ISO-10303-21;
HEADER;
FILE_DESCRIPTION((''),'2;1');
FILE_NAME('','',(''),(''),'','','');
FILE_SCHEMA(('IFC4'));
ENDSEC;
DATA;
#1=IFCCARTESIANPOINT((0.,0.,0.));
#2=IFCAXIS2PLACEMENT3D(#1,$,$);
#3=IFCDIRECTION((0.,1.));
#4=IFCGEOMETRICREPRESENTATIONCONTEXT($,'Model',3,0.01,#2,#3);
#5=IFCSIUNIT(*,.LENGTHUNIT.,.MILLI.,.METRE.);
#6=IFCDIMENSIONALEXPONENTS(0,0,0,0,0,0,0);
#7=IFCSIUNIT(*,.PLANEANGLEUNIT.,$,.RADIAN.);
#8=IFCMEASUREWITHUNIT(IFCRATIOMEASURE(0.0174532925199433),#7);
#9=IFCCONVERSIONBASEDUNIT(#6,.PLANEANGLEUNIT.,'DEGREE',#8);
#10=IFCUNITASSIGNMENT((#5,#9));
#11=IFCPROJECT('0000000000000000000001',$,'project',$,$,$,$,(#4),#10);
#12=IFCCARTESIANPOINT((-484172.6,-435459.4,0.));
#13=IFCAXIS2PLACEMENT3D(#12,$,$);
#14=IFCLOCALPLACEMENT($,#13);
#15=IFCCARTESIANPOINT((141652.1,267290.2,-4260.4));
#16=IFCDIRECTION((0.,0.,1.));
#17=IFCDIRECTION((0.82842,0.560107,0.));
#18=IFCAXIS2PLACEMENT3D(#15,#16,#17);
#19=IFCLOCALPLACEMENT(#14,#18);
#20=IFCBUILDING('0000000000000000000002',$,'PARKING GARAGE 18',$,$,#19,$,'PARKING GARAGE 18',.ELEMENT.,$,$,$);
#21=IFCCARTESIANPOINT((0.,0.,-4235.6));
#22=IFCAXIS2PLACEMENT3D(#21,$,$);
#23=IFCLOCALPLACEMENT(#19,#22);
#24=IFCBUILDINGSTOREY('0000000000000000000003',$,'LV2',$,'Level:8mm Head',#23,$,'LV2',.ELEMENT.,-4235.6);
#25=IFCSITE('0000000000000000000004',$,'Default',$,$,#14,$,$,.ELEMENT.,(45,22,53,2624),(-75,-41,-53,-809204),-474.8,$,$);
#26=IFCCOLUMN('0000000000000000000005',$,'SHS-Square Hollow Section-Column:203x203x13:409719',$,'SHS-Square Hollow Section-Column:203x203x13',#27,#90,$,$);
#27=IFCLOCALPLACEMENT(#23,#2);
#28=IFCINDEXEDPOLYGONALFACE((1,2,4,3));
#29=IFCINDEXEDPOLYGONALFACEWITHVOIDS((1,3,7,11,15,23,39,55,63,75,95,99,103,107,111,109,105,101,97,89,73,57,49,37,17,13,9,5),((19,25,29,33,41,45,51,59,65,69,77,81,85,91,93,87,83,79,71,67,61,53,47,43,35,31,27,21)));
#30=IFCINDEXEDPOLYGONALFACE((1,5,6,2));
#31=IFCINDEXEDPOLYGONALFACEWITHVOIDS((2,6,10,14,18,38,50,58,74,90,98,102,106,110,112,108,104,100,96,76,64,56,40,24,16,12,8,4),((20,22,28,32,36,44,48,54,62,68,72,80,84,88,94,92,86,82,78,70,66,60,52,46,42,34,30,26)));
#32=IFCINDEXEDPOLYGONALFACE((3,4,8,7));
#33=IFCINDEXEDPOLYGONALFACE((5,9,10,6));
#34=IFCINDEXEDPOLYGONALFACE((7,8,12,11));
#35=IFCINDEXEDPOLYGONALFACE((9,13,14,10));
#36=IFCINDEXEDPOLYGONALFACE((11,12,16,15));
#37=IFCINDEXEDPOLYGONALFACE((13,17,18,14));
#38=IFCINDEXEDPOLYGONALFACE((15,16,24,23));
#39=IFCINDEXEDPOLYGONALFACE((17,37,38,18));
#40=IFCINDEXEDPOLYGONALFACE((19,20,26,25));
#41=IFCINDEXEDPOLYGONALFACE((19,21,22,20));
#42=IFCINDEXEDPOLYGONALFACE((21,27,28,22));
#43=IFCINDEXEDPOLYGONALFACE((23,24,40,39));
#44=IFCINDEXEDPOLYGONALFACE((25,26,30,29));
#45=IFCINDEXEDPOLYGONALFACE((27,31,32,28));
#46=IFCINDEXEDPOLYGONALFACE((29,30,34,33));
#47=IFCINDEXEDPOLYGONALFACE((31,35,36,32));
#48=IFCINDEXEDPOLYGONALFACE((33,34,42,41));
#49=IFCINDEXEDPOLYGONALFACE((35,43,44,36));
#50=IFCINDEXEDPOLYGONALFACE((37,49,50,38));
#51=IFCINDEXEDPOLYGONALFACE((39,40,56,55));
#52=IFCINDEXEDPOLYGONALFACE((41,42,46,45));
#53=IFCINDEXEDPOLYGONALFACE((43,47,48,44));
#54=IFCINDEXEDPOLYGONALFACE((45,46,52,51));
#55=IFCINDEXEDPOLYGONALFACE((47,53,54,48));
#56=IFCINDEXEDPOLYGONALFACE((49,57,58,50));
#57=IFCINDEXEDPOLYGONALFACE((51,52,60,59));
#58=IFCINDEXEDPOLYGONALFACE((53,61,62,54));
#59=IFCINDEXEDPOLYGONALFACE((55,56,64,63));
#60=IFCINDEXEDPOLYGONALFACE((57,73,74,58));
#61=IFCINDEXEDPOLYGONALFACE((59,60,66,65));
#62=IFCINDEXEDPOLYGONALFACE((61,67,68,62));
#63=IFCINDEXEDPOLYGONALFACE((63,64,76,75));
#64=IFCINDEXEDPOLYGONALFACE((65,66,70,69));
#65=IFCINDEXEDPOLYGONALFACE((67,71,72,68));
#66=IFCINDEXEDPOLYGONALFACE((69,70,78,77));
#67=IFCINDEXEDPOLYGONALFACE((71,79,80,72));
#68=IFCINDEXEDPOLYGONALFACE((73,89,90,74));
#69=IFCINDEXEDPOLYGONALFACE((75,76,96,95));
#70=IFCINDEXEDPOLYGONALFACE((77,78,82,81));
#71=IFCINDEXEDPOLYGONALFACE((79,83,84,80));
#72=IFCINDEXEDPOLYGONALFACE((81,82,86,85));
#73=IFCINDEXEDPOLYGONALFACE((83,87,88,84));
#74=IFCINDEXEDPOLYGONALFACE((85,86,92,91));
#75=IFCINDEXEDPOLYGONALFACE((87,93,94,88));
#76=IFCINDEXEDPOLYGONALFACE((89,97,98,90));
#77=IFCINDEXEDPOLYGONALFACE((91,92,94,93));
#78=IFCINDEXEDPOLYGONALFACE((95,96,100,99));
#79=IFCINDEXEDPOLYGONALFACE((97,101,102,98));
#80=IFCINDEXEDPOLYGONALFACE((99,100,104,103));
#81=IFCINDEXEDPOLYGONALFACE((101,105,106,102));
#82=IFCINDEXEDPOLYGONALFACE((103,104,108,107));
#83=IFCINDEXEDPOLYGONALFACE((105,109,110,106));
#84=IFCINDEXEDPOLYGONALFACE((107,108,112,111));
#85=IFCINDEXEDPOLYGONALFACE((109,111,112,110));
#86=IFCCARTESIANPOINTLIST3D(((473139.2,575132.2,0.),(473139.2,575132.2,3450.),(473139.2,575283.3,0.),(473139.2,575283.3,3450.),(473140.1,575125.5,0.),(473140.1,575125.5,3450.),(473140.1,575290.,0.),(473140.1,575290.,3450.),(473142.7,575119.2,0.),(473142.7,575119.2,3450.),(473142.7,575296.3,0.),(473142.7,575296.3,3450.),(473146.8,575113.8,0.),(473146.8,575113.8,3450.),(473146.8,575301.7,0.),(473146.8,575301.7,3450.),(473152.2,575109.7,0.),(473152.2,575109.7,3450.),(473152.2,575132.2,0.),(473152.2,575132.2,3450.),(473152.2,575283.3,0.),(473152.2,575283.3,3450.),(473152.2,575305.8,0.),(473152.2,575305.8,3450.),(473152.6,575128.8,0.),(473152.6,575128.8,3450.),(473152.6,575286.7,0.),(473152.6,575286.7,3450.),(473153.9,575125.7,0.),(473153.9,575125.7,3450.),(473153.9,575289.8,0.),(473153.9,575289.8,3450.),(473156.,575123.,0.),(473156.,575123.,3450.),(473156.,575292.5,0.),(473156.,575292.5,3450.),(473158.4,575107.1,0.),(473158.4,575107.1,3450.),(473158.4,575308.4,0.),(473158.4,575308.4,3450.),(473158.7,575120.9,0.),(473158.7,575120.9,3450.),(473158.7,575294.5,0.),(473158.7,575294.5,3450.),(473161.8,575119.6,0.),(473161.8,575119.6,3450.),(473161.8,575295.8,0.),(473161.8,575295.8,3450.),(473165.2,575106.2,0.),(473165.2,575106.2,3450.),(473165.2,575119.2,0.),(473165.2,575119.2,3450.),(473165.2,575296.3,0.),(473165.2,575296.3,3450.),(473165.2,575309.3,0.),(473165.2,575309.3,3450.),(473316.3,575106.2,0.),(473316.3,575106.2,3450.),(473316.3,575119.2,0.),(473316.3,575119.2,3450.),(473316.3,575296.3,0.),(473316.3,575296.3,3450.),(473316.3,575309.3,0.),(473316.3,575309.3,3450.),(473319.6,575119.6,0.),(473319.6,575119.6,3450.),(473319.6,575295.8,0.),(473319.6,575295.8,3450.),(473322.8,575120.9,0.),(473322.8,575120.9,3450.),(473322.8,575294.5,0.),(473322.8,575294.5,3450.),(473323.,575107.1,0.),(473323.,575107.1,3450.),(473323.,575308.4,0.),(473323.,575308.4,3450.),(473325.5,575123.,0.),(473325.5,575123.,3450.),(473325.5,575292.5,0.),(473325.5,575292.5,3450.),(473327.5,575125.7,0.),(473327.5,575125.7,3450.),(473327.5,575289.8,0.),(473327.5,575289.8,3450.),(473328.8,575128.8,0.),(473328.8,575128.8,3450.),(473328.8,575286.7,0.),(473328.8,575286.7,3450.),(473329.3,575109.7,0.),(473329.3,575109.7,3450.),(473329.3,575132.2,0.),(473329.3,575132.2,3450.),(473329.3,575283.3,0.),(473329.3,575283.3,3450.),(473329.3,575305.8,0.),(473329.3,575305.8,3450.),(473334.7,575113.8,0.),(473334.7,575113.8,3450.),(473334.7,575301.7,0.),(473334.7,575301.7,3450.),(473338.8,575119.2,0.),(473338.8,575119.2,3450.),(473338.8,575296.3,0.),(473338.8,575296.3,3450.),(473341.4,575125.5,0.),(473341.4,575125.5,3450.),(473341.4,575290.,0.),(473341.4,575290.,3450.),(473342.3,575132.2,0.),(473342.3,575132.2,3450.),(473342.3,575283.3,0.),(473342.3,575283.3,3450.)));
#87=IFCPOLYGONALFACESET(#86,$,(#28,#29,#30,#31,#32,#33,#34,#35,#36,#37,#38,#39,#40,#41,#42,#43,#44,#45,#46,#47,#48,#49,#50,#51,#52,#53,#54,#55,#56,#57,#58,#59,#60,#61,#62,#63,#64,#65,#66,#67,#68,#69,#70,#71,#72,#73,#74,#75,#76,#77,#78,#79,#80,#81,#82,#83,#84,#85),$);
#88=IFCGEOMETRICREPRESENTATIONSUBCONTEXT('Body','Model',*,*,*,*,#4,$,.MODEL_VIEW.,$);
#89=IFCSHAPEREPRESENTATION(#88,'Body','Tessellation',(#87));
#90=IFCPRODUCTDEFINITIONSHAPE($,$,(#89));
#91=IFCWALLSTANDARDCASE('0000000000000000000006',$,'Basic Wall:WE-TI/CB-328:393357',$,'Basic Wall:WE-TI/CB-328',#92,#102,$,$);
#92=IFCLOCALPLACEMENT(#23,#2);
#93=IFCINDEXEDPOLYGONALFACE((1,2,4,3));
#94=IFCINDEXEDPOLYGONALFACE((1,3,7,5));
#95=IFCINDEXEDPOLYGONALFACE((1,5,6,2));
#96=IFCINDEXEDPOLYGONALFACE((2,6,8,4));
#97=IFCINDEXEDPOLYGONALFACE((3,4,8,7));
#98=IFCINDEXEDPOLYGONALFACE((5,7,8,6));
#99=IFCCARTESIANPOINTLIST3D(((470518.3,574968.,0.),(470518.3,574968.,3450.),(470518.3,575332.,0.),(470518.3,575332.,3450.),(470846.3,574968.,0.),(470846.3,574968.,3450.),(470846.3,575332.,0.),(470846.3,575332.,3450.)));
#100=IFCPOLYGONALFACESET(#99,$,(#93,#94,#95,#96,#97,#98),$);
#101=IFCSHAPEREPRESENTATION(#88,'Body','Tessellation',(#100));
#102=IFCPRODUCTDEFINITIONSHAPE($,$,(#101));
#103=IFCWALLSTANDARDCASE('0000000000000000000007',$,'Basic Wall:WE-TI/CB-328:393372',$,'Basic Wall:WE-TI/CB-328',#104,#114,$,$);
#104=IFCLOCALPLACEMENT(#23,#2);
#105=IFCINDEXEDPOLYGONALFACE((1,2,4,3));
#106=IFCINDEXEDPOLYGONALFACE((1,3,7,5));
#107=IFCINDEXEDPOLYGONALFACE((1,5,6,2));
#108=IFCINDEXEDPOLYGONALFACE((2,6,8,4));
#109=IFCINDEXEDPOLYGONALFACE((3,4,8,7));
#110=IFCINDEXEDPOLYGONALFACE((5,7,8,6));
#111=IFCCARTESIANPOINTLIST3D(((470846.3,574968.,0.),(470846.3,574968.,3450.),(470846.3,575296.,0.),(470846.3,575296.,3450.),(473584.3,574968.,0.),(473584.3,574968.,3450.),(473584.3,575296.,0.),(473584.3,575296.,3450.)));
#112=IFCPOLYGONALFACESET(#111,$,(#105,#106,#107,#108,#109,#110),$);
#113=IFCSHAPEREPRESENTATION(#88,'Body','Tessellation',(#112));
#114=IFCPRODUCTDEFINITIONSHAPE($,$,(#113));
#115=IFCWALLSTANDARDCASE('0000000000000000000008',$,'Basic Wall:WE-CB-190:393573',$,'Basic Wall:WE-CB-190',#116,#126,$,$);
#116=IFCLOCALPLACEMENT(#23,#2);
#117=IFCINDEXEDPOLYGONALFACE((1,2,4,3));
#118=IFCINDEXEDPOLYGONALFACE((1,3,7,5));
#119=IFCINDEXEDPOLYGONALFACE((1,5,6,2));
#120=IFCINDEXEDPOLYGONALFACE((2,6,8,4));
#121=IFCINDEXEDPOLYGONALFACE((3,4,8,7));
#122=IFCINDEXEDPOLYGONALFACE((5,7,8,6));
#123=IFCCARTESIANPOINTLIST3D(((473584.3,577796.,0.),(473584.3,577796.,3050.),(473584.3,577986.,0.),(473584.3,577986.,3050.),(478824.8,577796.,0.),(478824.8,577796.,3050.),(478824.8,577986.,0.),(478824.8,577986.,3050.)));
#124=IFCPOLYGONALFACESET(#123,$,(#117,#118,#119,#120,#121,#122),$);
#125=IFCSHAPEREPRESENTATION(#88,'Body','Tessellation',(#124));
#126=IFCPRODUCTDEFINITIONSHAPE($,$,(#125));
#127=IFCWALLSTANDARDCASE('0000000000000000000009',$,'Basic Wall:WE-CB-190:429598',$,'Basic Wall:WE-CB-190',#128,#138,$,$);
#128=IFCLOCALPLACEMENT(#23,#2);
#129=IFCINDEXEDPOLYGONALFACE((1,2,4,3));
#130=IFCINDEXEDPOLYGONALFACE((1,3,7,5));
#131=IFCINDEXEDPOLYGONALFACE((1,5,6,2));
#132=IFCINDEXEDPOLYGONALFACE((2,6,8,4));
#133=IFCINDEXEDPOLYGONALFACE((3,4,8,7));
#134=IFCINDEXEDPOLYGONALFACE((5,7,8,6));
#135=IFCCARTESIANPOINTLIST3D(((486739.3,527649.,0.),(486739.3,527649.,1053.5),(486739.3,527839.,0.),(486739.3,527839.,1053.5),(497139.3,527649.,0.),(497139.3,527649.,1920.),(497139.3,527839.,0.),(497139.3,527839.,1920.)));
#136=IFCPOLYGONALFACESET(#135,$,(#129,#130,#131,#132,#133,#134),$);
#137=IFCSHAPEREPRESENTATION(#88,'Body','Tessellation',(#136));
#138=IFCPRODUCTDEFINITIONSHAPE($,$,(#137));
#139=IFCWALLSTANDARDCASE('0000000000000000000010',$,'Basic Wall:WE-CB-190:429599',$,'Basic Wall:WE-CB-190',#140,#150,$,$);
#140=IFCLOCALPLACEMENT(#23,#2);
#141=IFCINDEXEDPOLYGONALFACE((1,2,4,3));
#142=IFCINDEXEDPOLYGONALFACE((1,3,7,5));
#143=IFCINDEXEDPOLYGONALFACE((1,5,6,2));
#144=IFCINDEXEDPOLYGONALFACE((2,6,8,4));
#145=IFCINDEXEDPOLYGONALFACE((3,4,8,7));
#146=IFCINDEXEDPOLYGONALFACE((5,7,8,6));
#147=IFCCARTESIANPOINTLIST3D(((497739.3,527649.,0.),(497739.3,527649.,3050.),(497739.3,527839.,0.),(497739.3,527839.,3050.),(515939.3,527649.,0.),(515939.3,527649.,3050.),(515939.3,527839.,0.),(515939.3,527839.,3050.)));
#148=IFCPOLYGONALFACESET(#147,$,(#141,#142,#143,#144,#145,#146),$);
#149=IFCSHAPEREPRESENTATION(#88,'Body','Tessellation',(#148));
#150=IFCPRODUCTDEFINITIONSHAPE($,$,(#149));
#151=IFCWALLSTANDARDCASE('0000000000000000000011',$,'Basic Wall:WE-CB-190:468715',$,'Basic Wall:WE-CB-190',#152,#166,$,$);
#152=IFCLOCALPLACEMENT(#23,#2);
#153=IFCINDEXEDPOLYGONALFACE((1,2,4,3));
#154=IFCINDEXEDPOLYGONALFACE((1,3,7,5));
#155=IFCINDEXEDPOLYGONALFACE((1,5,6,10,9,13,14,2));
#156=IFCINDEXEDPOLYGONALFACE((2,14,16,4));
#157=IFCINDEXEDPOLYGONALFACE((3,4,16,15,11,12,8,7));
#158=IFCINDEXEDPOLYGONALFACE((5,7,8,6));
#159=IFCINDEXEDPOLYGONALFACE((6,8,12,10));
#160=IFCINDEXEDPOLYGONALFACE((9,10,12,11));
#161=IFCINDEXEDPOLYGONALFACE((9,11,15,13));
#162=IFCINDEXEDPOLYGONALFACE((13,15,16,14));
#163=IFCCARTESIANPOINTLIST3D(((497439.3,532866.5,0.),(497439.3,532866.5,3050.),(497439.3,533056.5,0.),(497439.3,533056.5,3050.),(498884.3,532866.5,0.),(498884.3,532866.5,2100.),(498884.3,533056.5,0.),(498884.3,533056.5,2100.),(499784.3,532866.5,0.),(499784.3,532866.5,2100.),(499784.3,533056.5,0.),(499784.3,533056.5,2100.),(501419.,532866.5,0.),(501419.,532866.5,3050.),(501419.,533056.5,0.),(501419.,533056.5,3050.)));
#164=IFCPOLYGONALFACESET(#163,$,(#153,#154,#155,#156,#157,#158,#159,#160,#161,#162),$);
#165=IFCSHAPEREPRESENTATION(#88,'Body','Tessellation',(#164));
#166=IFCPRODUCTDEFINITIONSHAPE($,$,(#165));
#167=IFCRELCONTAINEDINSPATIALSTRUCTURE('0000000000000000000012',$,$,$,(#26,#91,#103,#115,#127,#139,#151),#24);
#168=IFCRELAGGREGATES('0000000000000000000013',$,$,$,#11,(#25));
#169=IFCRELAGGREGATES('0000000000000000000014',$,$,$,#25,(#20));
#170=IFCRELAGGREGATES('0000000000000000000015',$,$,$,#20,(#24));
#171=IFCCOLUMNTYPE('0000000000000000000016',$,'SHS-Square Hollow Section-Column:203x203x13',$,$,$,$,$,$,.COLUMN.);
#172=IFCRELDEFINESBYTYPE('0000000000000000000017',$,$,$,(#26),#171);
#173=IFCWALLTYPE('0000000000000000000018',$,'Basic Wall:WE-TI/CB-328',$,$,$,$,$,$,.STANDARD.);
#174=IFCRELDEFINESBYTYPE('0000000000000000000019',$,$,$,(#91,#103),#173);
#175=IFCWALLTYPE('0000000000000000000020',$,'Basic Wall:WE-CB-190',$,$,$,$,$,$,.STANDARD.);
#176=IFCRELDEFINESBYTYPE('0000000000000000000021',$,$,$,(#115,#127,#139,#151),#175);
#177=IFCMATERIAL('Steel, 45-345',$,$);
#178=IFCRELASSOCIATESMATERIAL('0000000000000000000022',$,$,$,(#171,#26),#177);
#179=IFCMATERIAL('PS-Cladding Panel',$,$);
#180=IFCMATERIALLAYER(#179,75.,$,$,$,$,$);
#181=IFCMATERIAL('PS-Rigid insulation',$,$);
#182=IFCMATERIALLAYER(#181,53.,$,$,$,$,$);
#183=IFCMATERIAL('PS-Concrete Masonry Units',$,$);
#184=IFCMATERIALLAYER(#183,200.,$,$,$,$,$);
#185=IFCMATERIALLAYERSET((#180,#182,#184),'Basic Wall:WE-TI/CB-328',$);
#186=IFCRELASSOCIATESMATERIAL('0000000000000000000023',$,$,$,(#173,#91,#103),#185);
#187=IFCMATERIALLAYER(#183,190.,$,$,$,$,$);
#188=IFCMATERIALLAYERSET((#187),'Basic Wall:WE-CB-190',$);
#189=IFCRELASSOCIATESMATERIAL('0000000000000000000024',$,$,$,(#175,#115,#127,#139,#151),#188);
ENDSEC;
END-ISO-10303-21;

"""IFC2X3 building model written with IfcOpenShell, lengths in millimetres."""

from ifc_helpers import new_model, entity, si_unit, converted_unit, direction, frame, frame_2d, origin, place, context, subcontext, project, spatial, polyline, circle_curve, parameter, trimmed, segment, composite_curve, rectangle, outline, extrude, clip, halfspace, source, transform, mapped, material, layer, layer_set, layer_usage, type_object, type_shapes, element, save


model = new_model("IFC2X3")

# Units and contexts
model_context = context("Model", 3, precision=0.01, world=origin(), true_north=direction((0.0, 1.0)))
body_context = subcontext(model_context, "Body", "Model", "MODEL_VIEW")
ifc_project = project(units=[si_unit("LENGTHUNIT", "METRE", prefix="MILLI"), converted_unit("PLANEANGLEUNIT", "DEGREE", entity("IfcRatioMeasure", 0.0174532925199433), si_unit("PLANEANGLEUNIT", "RADIAN"), dimensions=[0, 0, 0, 0, 0, 0, 0])], contexts=[model_context])

# Site, building, storey
site_placement = place(None, frame((-484172.6, -435459.4, 0.0)))
site = spatial("IfcSite", under=ifc_project, at=site_placement, Name="Default", CompositionType="ELEMENT", RefLatitude=(45, 22, 53, 2624), RefLongitude=(-75, -41, -53, -809204), RefElevation=-474.8)
building_placement = place(site_placement, frame((141652.1, 267290.2, -4260.4), z_axis=(0.0, 0.0, 1.0), x_axis=(0.82842, 0.560107, 0.0)))
building = spatial("IfcBuilding", under=site, at=building_placement, Name="PARKING GARAGE 18", LongName="PARKING GARAGE 18", CompositionType="ELEMENT")
storey_placement = place(building_placement, frame((0.0, 0.0, -4235.6)))
storey = spatial("IfcBuildingStorey", under=building, at=storey_placement, Name="LV2", ObjectType="Level:8mm Head", LongName="LV2", CompositionType="ELEMENT", Elevation=-4235.6)

# Column
ifc_material_1 = material(Name="Steel, 45-345")
column_type = type_object("IfcColumnType", Name="SHS-Square Hollow Section-Column:203x203x13", PredefinedType="COLUMN", material=ifc_material_1)
shared_shape_1 = source(origin(), body_context, "Body", "SweptSolid", [
    extrude(outline(composite_curve([segment(polyline([(-75.6, -101.5), (75.6, -101.5)]), True, "CONTINUOUS"), segment(trimmed(circle_curve(frame_2d((75.6, -75.6), x_axis=(-1.0, 0.0)), 26.0), [parameter(90.0)], [parameter(180.0)], True, "PARAMETER"), True, "CONTINUOUS"), segment(polyline([(101.5, -75.6), (101.5, 75.6)]), True, "CONTINUOUS"), segment(trimmed(circle_curve(frame_2d((75.5, 75.6), x_axis=(-1.0, 0.0)), 26.0), [parameter(180.0)], [parameter(270.0)], True, "PARAMETER"), True, "CONTINUOUS"), segment(polyline([(75.5, 101.6), (-75.5, 101.6)]), True, "CONTINUOUS"), segment(trimmed(circle_curve(frame_2d((-75.5, 75.5), x_axis=(-1.0, 0.0)), 26.0), [parameter(270.0)], [parameter(360.0)], True, "PARAMETER"), True, "CONTINUOUS"), segment(polyline([(-101.5, 75.5), (-101.5, -75.6)]), True, "CONTINUOUS"), segment(trimmed(circle_curve(frame_2d((-75.6, -75.6), x_axis=(-1.0, 0.0)), 26.0), [parameter(360.0)], [parameter(90.0)], True, "PARAMETER"), True, "CONTINUOUS")], self_intersect=False), holes=[composite_curve([segment(trimmed(circle_curve(frame_2d((-75.6, -75.6), x_axis=(-1.0, 0.0)), 13.0), [parameter(0.0)], [parameter(90.0)], True, "PARAMETER"), False, "CONTINUOUS"), segment(polyline([(-88.5, -75.6), (-88.5, 75.6)]), True, "CONTINUOUS"), segment(trimmed(circle_curve(frame_2d((-75.6, 75.6), x_axis=(-1.0, 0.0)), 13.0), [parameter(270.0)], [parameter(0.0)], True, "PARAMETER"), False, "CONTINUOUS"), segment(polyline([(-75.6, 88.6), (75.5, 88.6)]), True, "CONTINUOUS"), segment(trimmed(circle_curve(frame_2d((75.5, 75.5), x_axis=(-1.0, 0.0)), 13.0), [parameter(180.0)], [parameter(270.0)], True, "PARAMETER"), False, "CONTINUOUS"), segment(polyline([(88.6, 75.5), (88.6, -75.5)]), True, "CONTINUOUS"), segment(trimmed(circle_curve(frame_2d((75.6, -75.5), x_axis=(-1.0, 0.0)), 13.0), [parameter(90.0)], [parameter(180.0)], True, "PARAMETER"), False, "CONTINUOUS"), segment(polyline([(75.6, -88.5), (-75.6, -88.5)]), True, "CONTINUOUS")], self_intersect=False)]), frame((0.0, 0.0, -4235.6), z_axis=(0.0, 0.0, 1.0), x_axis=(-1.0, 0.0, 0.0)), (0.0, 0.0, 1.0), 3450.0),
])
type_shapes(column_type, [shared_shape_1])
for number, where, name in (
    (1, (473240.7, 575207.7, 4235.6), "SHS-Square Hollow Section-Column:203x203x13:409719"),
):
    element("IfcColumn", number, at=place(storey_placement, frame(where)), inside=storey, type_object=column_type, material=ifc_material_1, Name=name, ObjectType="SHS-Square Hollow Section-Column:203x203x13", context=body_context, shape_type="MappedRepresentation", body=[
        mapped(shared_shape_1, transform((0.0, 0.0, 0.0), scale=1.0)),
    ])

# Walls
ifc_material_2 = material(Name="PS-Cladding Panel")
ifc_layer_1 = layer(ifc_material_2, 75.0)
ifc_material_3 = material(Name="PS-Rigid insulation")
ifc_layer_2 = layer(ifc_material_3, 53.0)
ifc_material_4 = material(Name="PS-Concrete Masonry Units")
ifc_layer_3 = layer(ifc_material_4, 200.0)
ifc_layer_set_1 = layer_set([ifc_layer_1, ifc_layer_2, ifc_layer_3], Name="Basic Wall:WE-TI/CB-328")
ifc_layer_usage_1 = layer_usage(ifc_layer_set_1, "AXIS2", "POSITIVE", -164.0)
wall_type_1 = type_object("IfcWallType", Name="Basic Wall:WE-TI/CB-328", PredefinedType="STANDARD", material=ifc_layer_set_1)
wall_1_placement = place(storey_placement, frame((470682.3, 575332.0, 0.0), z_axis=(0.0, 0.0, 1.0), x_axis=(0.0, -1.0, 0.0)))
element("IfcWallStandardCase", 2, at=wall_1_placement, inside=storey, type_object=wall_type_1, material=ifc_layer_usage_1, Name="Basic Wall:WE-TI/CB-328:393357", ObjectType="Basic Wall:WE-TI/CB-328", context=body_context, shape_type="SweptSolid", body=[
    extrude(rectangle(XDim=364.0, YDim=328.0, at=frame_2d((182.0, 0.0), x_axis=(-1.0, 0.0))), origin(), (0.0, 0.0, 1.0), 3450.0),
])
ifc_layer_usage_2 = layer_usage(ifc_layer_set_1, "AXIS2", "POSITIVE", -164.0)
wall_2_placement = place(storey_placement, frame((470846.3, 575132.0, 0.0)))
element("IfcWallStandardCase", 3, at=wall_2_placement, inside=storey, type_object=wall_type_1, material=ifc_layer_usage_2, Name="Basic Wall:WE-TI/CB-328:393372", ObjectType="Basic Wall:WE-TI/CB-328", context=body_context, shape_type="SweptSolid", body=[
    extrude(rectangle(XDim=2738.0, YDim=328.0, at=frame_2d((1369.0, 0.0), x_axis=(-1.0, 0.0))), origin(), (0.0, 0.0, 1.0), 3450.0),
])
ifc_layer_4 = layer(ifc_material_4, 190.0)
ifc_layer_set_2 = layer_set([ifc_layer_4], Name="Basic Wall:WE-CB-190")
ifc_layer_usage_3 = layer_usage(ifc_layer_set_2, "AXIS2", "NEGATIVE", 95.0)
wall_type_2 = type_object("IfcWallType", Name="Basic Wall:WE-CB-190", PredefinedType="STANDARD", material=ifc_layer_set_2)
wall_3_placement = place(storey_placement, frame((473584.3, 577891.0, 0.0)))
element("IfcWallStandardCase", 4, at=wall_3_placement, inside=storey, type_object=wall_type_2, material=ifc_layer_usage_3, Name="Basic Wall:WE-CB-190:393573", ObjectType="Basic Wall:WE-CB-190", context=body_context, shape_type="SweptSolid", body=[
    extrude(rectangle(XDim=5240.5, YDim=190.0, at=frame_2d((2620.2, 0.0), x_axis=(-1.0, 0.0))), origin(), (0.0, 0.0, 1.0), 3050.0),
])
ifc_layer_usage_4 = layer_usage(ifc_layer_set_2, "AXIS2", "NEGATIVE", 95.0)
wall_4_placement = place(storey_placement, frame((486739.3, 527744.0, 0.0)))
element("IfcWallStandardCase", 5, at=wall_4_placement, inside=storey, type_object=wall_type_2, material=ifc_layer_usage_4, Name="Basic Wall:WE-CB-190:429598", ObjectType="Basic Wall:WE-CB-190", context=body_context, shape_type="Clipping", body=[
    clip(extrude(rectangle(XDim=10400.0, YDim=190.0, at=frame_2d((5200.0, 0.0), x_axis=(-1.0, 0.0))), origin(), (0.0, 0.0, 1.0), 1920.0), halfspace(frame((0.0, -95.0, 1053.5), z_axis=(-0.083029, 0.0, 0.996547), x_axis=(0.0, 1.0, 0.0)), False)),
])
ifc_layer_usage_5 = layer_usage(ifc_layer_set_2, "AXIS2", "NEGATIVE", 95.0)
wall_5_placement = place(storey_placement, frame((497739.3, 527744.0, 0.0)))
element("IfcWallStandardCase", 6, at=wall_5_placement, inside=storey, type_object=wall_type_2, material=ifc_layer_usage_5, Name="Basic Wall:WE-CB-190:429599", ObjectType="Basic Wall:WE-CB-190", context=body_context, shape_type="SweptSolid", body=[
    extrude(rectangle(XDim=18200.0, YDim=190.0, at=frame_2d((9100.0, 0.0), x_axis=(-1.0, 0.0))), origin(), (0.0, 0.0, 1.0), 3050.0),
])

# Wall, opening
ifc_layer_usage_6 = layer_usage(ifc_layer_set_2, "AXIS2", "NEGATIVE", 95.0)
wall_6_placement = place(storey_placement, frame((497439.3, 532961.5, 0.0)))
wall_6 = element("IfcWallStandardCase", 7, at=wall_6_placement, inside=storey, type_object=wall_type_2, material=ifc_layer_usage_6, Name="Basic Wall:WE-CB-190:468715", ObjectType="Basic Wall:WE-CB-190", context=body_context, shape_type="SweptSolid", body=[
    extrude(rectangle(XDim=3979.7, YDim=190.0, at=frame_2d((1989.9, 0.0), x_axis=(-1.0, 0.0))), origin(), (0.0, 0.0, 1.0), 3050.0),
])
opening_placement = place(wall_6_placement, origin())
element("IfcOpeningElement", 8, at=opening_placement, cuts=wall_6, ObjectType="Opening", context=body_context, shape_type="SweptSolid", body=[
    extrude(rectangle(XDim=2100.0, YDim=900.0, at=frame_2d((0.0, 0.0), x_axis=(1.0, 0.0))), frame((1895.0, -1429.0, 1050.0), z_axis=(0.0, 1.0, 0.0), x_axis=(0.0, 0.0, 1.0)), (0.0, 0.0, 1.0), 3048.0),
])

save(model, "model.ifc")
